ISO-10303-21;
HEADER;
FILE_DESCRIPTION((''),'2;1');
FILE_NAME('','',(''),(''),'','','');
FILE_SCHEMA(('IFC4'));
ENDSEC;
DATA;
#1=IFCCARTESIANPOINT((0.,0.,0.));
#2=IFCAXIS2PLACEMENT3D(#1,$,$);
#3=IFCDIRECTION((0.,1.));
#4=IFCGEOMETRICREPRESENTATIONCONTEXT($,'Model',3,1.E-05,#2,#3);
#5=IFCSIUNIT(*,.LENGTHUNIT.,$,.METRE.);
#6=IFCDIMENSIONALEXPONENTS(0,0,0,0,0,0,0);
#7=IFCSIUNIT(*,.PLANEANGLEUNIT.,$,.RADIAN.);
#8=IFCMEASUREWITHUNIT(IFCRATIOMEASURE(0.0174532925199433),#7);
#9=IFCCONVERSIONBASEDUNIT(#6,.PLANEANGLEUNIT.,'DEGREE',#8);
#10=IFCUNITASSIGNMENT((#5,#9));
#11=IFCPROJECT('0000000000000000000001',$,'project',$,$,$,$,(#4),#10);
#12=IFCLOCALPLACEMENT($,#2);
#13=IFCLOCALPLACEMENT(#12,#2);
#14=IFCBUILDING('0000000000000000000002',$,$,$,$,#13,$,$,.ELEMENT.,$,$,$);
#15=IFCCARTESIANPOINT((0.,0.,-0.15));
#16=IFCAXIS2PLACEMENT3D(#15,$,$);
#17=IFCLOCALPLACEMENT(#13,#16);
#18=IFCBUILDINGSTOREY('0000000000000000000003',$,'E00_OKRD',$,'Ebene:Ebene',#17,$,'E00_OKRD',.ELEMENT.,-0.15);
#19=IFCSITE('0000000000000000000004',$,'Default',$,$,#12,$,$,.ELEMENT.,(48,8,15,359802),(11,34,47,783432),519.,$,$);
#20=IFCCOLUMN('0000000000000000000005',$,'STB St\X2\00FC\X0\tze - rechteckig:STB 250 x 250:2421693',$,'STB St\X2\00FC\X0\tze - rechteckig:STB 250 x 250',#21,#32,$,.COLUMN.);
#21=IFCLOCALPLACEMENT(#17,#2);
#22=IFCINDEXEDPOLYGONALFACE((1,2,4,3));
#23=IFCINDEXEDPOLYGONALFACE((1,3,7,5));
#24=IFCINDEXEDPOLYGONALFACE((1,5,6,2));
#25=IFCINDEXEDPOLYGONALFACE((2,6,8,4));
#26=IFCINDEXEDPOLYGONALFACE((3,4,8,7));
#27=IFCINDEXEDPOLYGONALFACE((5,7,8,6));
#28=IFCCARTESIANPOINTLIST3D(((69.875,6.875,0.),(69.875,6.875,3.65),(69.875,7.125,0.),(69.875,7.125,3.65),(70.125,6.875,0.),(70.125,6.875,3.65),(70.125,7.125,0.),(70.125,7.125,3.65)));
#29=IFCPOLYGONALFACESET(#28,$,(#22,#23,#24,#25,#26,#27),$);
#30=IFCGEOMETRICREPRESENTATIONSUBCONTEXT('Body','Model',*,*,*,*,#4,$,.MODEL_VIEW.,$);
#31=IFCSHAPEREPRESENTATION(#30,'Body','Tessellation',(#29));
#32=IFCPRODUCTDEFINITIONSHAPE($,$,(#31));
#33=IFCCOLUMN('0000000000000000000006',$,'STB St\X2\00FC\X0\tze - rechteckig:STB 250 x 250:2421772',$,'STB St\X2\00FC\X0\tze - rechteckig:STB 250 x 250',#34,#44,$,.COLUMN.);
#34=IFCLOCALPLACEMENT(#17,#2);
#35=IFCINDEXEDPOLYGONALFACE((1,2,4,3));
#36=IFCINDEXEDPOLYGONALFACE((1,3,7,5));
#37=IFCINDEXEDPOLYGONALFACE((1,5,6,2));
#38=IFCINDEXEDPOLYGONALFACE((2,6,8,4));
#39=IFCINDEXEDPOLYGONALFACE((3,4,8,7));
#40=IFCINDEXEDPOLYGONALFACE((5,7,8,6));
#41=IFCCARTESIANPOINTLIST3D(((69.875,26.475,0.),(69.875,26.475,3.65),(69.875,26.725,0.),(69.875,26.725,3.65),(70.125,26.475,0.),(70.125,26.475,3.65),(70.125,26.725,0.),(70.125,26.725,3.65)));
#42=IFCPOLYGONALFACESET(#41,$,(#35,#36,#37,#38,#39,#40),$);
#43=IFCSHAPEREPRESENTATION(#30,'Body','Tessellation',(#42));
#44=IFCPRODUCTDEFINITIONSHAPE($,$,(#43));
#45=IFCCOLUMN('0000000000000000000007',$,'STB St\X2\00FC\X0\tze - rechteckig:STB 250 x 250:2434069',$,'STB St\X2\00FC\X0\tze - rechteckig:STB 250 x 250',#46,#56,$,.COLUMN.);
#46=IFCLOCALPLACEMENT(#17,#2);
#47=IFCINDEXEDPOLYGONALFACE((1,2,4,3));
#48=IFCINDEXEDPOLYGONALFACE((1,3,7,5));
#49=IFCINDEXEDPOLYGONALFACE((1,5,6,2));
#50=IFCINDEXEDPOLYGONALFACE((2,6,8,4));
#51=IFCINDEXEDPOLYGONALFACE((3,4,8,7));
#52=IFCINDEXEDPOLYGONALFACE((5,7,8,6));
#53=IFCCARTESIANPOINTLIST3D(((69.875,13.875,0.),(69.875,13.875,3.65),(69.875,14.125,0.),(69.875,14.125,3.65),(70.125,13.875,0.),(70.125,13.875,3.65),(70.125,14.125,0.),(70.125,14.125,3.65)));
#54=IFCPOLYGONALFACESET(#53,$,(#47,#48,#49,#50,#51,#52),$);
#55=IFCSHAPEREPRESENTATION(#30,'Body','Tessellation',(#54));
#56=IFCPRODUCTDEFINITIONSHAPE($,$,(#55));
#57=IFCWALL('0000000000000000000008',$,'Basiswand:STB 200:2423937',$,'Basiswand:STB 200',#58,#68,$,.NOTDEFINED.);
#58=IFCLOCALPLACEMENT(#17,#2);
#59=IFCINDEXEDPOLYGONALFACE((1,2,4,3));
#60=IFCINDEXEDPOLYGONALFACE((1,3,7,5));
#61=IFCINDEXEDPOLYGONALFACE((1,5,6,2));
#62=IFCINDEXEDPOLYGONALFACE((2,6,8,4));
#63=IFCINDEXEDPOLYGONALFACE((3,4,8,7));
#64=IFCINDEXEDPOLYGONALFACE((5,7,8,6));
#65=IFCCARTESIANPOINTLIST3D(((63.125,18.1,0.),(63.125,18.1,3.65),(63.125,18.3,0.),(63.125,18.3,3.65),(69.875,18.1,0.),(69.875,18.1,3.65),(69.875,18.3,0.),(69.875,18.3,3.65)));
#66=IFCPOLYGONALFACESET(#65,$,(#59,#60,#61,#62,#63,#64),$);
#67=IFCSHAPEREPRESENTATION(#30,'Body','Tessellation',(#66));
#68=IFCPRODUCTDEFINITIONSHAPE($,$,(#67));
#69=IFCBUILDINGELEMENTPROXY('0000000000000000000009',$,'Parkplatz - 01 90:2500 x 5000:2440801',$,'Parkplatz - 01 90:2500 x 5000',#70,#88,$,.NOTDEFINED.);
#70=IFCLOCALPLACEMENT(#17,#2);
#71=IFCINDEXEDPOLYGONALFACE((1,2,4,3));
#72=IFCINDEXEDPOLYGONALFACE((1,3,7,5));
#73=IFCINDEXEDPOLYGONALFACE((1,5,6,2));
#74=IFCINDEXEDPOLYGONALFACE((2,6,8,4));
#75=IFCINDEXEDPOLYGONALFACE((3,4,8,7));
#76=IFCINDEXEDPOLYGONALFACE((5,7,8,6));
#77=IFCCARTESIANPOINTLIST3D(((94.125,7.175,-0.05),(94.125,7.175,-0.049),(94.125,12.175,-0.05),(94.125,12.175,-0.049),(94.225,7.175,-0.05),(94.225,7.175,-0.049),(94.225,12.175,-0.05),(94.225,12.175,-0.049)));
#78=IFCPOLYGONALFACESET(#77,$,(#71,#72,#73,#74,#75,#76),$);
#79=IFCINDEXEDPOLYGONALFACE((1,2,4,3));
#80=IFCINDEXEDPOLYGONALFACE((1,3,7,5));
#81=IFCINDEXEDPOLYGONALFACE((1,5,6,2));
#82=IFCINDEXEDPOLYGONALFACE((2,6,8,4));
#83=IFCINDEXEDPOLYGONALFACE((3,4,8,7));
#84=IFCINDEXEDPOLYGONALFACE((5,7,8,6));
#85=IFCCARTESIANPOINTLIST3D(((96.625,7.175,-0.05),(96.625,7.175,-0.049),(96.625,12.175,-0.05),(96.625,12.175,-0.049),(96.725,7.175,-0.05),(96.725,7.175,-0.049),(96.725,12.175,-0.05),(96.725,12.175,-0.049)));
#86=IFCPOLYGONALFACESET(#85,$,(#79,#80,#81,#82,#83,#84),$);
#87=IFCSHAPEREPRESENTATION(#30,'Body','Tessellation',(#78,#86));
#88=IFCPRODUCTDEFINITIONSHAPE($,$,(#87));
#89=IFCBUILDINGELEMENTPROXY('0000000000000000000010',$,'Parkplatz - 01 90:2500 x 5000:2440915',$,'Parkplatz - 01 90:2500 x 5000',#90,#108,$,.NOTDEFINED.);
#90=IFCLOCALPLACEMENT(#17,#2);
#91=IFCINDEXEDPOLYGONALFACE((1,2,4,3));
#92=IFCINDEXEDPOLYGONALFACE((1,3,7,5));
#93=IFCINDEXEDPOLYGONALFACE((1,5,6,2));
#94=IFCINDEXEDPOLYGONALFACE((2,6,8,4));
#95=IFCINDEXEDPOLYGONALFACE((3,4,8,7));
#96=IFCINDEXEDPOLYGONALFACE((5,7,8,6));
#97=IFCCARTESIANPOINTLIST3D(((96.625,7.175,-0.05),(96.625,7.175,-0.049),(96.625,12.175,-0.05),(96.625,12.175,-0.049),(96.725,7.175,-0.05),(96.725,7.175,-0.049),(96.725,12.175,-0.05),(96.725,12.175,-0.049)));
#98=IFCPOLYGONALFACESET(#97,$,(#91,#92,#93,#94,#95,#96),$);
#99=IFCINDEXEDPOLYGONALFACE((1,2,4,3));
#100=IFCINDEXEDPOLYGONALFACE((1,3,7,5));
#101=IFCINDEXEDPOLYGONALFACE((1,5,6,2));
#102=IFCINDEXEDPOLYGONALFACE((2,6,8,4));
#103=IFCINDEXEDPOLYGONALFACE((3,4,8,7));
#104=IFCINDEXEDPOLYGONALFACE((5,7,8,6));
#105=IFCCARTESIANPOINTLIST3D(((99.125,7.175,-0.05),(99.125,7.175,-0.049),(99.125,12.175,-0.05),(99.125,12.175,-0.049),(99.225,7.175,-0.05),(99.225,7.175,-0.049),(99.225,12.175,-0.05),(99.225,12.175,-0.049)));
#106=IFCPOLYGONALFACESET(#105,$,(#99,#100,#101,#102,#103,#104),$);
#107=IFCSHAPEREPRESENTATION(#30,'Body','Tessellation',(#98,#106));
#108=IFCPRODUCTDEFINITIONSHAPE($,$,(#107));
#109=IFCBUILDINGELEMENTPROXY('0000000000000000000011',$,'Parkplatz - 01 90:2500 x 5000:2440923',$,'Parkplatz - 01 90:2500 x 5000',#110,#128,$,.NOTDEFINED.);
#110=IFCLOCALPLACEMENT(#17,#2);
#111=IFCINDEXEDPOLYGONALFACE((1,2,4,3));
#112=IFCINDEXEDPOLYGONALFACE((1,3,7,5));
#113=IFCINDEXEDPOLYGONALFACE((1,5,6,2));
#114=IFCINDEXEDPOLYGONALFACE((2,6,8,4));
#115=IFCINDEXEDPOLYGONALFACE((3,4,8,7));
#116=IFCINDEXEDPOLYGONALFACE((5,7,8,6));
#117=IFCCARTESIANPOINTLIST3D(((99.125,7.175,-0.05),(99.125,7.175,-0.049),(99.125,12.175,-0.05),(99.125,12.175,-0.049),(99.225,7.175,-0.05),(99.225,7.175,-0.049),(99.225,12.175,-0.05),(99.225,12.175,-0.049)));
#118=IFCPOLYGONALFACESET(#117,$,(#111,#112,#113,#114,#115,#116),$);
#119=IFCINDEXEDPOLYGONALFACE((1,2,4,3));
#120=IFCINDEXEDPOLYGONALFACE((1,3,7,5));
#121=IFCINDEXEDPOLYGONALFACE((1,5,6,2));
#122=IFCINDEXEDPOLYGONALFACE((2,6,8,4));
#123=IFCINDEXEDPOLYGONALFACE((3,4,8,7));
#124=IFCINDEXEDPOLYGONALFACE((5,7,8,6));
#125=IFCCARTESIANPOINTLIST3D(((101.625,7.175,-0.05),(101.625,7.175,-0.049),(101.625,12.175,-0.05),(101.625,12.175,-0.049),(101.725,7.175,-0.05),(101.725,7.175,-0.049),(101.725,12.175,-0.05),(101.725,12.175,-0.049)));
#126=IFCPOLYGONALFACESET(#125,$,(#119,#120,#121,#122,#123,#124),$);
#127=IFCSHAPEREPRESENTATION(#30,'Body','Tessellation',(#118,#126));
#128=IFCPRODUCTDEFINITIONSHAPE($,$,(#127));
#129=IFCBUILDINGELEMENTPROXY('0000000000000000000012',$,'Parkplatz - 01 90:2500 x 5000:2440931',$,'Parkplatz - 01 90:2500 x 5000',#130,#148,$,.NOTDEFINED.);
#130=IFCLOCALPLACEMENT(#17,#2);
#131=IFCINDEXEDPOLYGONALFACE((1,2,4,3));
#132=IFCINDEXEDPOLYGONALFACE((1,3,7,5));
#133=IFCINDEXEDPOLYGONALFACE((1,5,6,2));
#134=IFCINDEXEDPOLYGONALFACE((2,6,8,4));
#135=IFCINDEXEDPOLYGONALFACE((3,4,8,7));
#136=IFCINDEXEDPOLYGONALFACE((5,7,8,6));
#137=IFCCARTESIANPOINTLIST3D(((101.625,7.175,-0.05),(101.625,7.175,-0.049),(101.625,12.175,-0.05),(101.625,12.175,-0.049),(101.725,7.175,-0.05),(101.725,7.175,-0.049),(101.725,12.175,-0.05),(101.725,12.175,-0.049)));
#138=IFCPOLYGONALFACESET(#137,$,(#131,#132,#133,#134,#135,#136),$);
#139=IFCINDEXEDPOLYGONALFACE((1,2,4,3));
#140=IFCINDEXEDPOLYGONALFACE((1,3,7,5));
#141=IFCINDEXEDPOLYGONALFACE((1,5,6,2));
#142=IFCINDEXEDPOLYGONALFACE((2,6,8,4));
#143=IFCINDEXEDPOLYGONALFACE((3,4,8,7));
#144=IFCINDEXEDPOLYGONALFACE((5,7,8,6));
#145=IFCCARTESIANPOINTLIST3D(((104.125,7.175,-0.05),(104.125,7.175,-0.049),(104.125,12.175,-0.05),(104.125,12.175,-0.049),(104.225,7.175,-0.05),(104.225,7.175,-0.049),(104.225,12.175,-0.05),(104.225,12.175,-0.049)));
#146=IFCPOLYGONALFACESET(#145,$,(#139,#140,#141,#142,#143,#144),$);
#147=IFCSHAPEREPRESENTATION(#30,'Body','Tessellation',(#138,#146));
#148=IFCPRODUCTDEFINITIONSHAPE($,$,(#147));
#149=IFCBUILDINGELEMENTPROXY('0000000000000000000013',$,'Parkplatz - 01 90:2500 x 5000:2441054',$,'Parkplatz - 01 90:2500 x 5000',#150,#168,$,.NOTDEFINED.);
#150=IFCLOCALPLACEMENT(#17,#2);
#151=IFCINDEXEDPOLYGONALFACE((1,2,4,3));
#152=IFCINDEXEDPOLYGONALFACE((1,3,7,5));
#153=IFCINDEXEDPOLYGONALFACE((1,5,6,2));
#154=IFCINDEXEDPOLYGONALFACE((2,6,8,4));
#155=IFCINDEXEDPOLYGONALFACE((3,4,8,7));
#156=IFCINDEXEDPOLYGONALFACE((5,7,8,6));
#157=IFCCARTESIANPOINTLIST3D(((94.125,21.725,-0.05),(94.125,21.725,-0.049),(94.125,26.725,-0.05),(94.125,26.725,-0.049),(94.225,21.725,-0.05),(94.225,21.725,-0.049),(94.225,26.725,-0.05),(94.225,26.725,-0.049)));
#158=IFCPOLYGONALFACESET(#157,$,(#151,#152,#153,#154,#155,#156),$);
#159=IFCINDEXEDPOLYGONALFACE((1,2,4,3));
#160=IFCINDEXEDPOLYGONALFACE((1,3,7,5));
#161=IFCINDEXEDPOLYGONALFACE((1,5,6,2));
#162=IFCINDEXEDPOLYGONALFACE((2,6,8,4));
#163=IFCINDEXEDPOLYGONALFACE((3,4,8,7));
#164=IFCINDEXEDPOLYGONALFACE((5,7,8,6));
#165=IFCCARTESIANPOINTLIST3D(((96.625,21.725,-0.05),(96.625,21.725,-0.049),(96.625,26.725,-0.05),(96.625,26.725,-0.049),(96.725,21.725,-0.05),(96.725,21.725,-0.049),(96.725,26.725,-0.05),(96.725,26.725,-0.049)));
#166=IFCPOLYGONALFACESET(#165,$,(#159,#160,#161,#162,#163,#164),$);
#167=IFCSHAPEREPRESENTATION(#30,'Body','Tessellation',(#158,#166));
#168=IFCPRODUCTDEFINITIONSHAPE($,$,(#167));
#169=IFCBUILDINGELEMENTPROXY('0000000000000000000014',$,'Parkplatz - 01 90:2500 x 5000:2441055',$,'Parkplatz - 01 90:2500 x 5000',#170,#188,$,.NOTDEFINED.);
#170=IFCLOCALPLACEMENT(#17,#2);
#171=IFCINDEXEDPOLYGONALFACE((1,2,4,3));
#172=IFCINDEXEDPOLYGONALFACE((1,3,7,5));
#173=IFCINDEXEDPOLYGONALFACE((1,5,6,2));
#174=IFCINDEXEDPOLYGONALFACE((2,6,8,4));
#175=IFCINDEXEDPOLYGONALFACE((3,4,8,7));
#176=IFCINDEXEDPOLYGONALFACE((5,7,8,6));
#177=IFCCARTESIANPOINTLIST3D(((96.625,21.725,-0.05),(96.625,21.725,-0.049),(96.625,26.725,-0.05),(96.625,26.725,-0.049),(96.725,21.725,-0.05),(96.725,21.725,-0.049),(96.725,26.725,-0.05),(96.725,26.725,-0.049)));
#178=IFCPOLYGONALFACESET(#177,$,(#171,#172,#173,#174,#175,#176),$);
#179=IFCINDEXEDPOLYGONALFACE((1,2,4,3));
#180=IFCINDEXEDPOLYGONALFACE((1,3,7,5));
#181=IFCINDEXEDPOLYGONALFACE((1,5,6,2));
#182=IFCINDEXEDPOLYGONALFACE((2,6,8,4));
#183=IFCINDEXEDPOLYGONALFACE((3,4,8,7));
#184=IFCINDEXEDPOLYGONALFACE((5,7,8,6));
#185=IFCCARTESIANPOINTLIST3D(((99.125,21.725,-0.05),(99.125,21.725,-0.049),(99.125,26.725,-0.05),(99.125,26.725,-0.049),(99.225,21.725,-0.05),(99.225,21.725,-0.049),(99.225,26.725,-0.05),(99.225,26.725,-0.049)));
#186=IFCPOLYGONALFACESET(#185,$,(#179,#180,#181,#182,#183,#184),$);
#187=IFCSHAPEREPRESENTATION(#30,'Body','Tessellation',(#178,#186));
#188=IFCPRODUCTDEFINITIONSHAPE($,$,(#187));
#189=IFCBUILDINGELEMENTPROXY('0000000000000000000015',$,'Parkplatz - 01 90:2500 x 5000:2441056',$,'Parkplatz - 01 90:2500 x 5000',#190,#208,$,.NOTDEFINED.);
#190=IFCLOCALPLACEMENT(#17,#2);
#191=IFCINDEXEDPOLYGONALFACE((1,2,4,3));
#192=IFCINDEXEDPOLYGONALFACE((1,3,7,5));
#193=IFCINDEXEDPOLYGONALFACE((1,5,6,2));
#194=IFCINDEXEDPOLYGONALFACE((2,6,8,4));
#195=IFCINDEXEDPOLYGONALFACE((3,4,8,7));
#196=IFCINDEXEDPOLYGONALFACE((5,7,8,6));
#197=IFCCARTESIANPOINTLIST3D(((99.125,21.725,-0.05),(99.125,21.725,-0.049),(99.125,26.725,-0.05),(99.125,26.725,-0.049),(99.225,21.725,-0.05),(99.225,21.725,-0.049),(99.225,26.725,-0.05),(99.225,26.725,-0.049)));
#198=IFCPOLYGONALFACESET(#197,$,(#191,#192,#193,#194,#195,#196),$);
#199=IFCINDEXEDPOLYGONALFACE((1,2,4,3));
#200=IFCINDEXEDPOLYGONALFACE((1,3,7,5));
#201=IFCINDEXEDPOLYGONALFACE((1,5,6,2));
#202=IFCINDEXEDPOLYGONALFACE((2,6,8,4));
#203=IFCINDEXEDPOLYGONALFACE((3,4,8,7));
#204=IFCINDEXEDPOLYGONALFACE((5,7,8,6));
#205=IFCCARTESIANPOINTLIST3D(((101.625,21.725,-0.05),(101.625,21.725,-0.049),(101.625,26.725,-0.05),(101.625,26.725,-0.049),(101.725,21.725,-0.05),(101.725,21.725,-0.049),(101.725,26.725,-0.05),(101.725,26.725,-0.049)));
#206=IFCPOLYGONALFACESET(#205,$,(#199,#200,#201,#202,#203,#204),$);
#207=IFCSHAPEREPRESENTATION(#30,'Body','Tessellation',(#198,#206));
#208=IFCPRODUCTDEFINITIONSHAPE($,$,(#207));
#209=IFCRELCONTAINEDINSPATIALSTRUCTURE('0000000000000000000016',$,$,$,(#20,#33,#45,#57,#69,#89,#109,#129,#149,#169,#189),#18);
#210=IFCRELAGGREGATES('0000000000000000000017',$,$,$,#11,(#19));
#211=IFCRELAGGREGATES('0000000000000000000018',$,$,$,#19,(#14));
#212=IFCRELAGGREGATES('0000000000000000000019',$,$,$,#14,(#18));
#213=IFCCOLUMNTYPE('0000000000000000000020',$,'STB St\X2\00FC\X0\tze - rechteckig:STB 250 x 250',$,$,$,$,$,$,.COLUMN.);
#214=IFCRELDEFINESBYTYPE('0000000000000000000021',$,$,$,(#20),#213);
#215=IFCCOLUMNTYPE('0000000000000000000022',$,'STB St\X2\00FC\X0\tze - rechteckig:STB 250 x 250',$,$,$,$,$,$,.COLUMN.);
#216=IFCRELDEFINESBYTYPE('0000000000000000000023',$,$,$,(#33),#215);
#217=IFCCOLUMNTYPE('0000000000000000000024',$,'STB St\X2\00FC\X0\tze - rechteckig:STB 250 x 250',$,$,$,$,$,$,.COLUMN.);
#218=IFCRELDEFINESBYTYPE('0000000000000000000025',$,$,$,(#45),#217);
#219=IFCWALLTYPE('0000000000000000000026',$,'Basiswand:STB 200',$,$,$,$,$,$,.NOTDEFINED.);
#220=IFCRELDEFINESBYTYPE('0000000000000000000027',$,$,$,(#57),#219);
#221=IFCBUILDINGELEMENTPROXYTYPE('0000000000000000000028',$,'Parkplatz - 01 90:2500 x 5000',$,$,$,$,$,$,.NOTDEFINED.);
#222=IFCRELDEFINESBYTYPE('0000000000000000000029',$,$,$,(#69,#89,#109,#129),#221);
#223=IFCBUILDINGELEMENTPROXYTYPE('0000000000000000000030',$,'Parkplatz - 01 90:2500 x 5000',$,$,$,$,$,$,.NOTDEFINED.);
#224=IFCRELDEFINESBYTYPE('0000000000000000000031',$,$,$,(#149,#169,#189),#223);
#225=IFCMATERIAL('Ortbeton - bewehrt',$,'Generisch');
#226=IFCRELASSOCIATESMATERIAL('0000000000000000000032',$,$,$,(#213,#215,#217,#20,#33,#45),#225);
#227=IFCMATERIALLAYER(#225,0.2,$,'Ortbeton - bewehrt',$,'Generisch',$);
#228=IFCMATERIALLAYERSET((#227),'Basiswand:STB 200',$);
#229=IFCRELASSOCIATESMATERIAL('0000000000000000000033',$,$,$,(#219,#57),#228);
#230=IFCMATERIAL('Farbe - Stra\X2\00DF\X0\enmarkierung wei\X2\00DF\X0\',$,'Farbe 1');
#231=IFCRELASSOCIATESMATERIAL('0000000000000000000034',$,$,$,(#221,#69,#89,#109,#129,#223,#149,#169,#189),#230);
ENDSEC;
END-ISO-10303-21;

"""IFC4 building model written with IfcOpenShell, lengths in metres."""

from ifc_helpers import new_model, entity, si_unit, converted_unit, direction, frame, frame_2d, origin, origin_2d_with_axis, place, context, subcontext, project, spatial, rectangle, extrude, source, transform, mapped, material, layer, layer_set, layer_usage, material_profile, profile_set, profile_usage, type_object, type_shapes, element, save


model = new_model("IFC4")

# Units and contexts
model_context = context("Model", 3, precision=1e-05, world=origin(), true_north=direction((0.0, 1.0)))
body_context = subcontext(model_context, "Body", "Model", "MODEL_VIEW")
ifc_project = project(units=[si_unit("LENGTHUNIT", "METRE"), converted_unit("PLANEANGLEUNIT", "DEGREE", entity("IfcRatioMeasure", 0.0174532925199433), si_unit("PLANEANGLEUNIT", "RADIAN"), dimensions=[0, 0, 0, 0, 0, 0, 0])], contexts=[model_context])

# Site, building, storey
site_placement = place(None, frame((0.0, 0.0, 0.0)))
site = spatial("IfcSite", under=ifc_project, at=site_placement, Name="Default", CompositionType="ELEMENT", RefLatitude=(48, 8, 15, 359802), RefLongitude=(11, 34, 47, 783432), RefElevation=519.0)
building_placement = place(site_placement, origin())
building = spatial("IfcBuilding", under=site, at=building_placement, CompositionType="ELEMENT")
storey_placement = place(building_placement, frame((0.0, 0.0, -0.15)))
storey = spatial("IfcBuildingStorey", under=building, at=storey_placement, Name="E00_OKRD", ObjectType="Ebene:Ebene", LongName="E00_OKRD", CompositionType="ELEMENT", Elevation=-0.15)

# Columns
ifc_material_1 = material(Name="Ortbeton - bewehrt", Category="Generisch")
ifc_material_profile = material_profile(ifc_material_1, rectangle(XDim=0.25, YDim=0.25, at=origin_2d_with_axis()), Name="STB 250 x 250")
ifc_profile_set = profile_set([ifc_material_profile], Name="STB 250 x 250")
ifc_profile_usage_1 = profile_usage(ifc_profile_set)
column_type_1 = type_object("IfcColumnType", Name="STB Stütze - rechteckig:STB 250 x 250", PredefinedType="COLUMN", material=ifc_profile_set)
shared_shape_1 = source(origin(), body_context, "Body", "SweptSolid", [
    extrude(rectangle(XDim=0.25, YDim=0.25, at=frame_2d((0.0, 0.0), x_axis=(1.0, 0.0))), frame((0.125, 0.125, 0.0), z_axis=(0.0, 0.0, 1.0), x_axis=(-1.0, 0.0, 0.0)), (0.0, 0.0, 1.0), 3.65),
])
type_shapes(column_type_1, [shared_shape_1])
column_1_placement = place(storey_placement, frame((69.875, 6.875, 0.0)))
element("IfcColumn", 1, at=column_1_placement, inside=storey, type_object=column_type_1, material=ifc_profile_usage_1, Name="STB Stütze - rechteckig:STB 250 x 250:2421693", ObjectType="STB Stütze - rechteckig:STB 250 x 250", PredefinedType="COLUMN", context=body_context, shape_type="MappedRepresentation", body=[
    mapped(shared_shape_1, transform((0.0, 0.0, 0.0), scale=1.0)),
])
ifc_profile_usage_2 = profile_usage(ifc_profile_set)
column_type_2 = type_object("IfcColumnType", Name="STB Stütze - rechteckig:STB 250 x 250", PredefinedType="COLUMN", material=ifc_profile_set)
shared_shape_2 = source(origin(), body_context, "Body", "SweptSolid", [
    extrude(rectangle(XDim=0.25, YDim=0.25, at=frame_2d((0.0, 0.0), x_axis=(1.0, 0.0))), frame((0.125, 0.125, 0.0), z_axis=(0.0, 0.0, 1.0), x_axis=(-1.0, 0.0, 0.0)), (0.0, 0.0, 1.0), 3.65),
])
type_shapes(column_type_2, [shared_shape_2])
column_2_placement = place(storey_placement, frame((69.875, 26.475, 0.0)))
element("IfcColumn", 2, at=column_2_placement, inside=storey, type_object=column_type_2, material=ifc_profile_usage_2, Name="STB Stütze - rechteckig:STB 250 x 250:2421772", ObjectType="STB Stütze - rechteckig:STB 250 x 250", PredefinedType="COLUMN", context=body_context, shape_type="MappedRepresentation", body=[
    mapped(shared_shape_2, transform((0.0, 0.0, 0.0), scale=1.0)),
])
ifc_profile_usage_3 = profile_usage(ifc_profile_set)
column_type_3 = type_object("IfcColumnType", Name="STB Stütze - rechteckig:STB 250 x 250", PredefinedType="COLUMN", material=ifc_profile_set)
shared_shape_3 = source(origin(), body_context, "Body", "SweptSolid", [
    extrude(rectangle(XDim=0.25, YDim=0.25, at=frame_2d((0.0, 0.0), x_axis=(1.0, 0.0))), frame((0.125, 0.125, 0.0), z_axis=(0.0, 0.0, 1.0), x_axis=(-1.0, 0.0, 0.0)), (0.0, 0.0, 1.0), 3.65),
])
type_shapes(column_type_3, [shared_shape_3])
column_3_placement = place(storey_placement, frame((69.875, 13.875, 0.0)))
element("IfcColumn", 3, at=column_3_placement, inside=storey, type_object=column_type_3, material=ifc_profile_usage_3, Name="STB Stütze - rechteckig:STB 250 x 250:2434069", ObjectType="STB Stütze - rechteckig:STB 250 x 250", PredefinedType="COLUMN", context=body_context, shape_type="MappedRepresentation", body=[
    mapped(shared_shape_3, transform((0.0, 0.0, 0.0), scale=1.0)),
])

# Wall
ifc_layer = layer(ifc_material_1, 0.2, Name="Ortbeton - bewehrt", Category="Generisch")
ifc_layer_set = layer_set([ifc_layer], Name="Basiswand:STB 200")
ifc_layer_usage = layer_usage(ifc_layer_set, "AXIS2", "NEGATIVE", 0.1)
wall_type = type_object("IfcWallType", Name="Basiswand:STB 200", PredefinedType="NOTDEFINED", material=ifc_layer_set)
wall_placement = place(storey_placement, frame((69.875, 18.2, 0.0), z_axis=(0.0, 0.0, 1.0), x_axis=(-1.0, 0.0, 0.0)))
element("IfcWall", 4, at=wall_placement, inside=storey, type_object=wall_type, material=ifc_layer_usage, Name="Basiswand:STB 200:2423937", ObjectType="Basiswand:STB 200", PredefinedType="NOTDEFINED", context=body_context, shape_type="SweptSolid", body=[
    extrude(rectangle(XDim=6.75, YDim=0.2, at=frame_2d((3.375, 0.0), x_axis=(-1.0, 0.0))), origin(), (0.0, 0.0, 1.0), 3.65),
])

# Building element proxies
ifc_material_2 = material(Name="Farbe - Straßenmarkierung weiß", Category="Farbe 1")
building_element_proxy_type_1 = type_object("IfcBuildingElementProxyType", Name="Parkplatz - 01 90:2500 x 5000", PredefinedType="NOTDEFINED", material=ifc_material_2)
shared_shape_4 = source(origin(), body_context, "Body", "SweptSolid", [
    extrude(rectangle(XDim=5.0, YDim=0.1, at=origin_2d_with_axis()), frame((2.5456, -2.5, 0.0), z_axis=(0.0, 0.0, 1.0), x_axis=(0.0, -1.0, 0.0)), (0.0, 0.0, 1.0), 0.001),
    extrude(rectangle(XDim=0.1, YDim=5.0, at=origin_2d_with_axis()), frame((0.0456, -2.5, 0.0), z_axis=(0.0, 0.0, 1.0), x_axis=(-1.0, 0.0, 0.0)), (0.0, 0.0, 1.0), 0.001),
])
type_shapes(building_element_proxy_type_1, [shared_shape_4])
for number, where, z_axis, x_axis, name in (
    (5, (96.7206, 7.175, -0.05), (0.0, 0.0, 1.0), (-1.0, 0.0, 0.0), "Parkplatz - 01 90:2500 x 5000:2440801"),
    (6, (99.2206, 7.175, -0.05), (0.0, 0.0, 1.0), (-1.0, 0.0, 0.0), "Parkplatz - 01 90:2500 x 5000:2440915"),
    (7, (101.7206, 7.175, -0.05), (0.0, 0.0, 1.0), (-1.0, 0.0, 0.0), "Parkplatz - 01 90:2500 x 5000:2440923"),
    (8, (104.2206, 7.175, -0.05), (0.0, 0.0, 1.0), (-1.0, 0.0, 0.0), "Parkplatz - 01 90:2500 x 5000:2440931"),
):
    element("IfcBuildingElementProxy", number, at=place(storey_placement, frame(where, z_axis=z_axis, x_axis=x_axis)), inside=storey, type_object=building_element_proxy_type_1, material=ifc_material_2, Name=name, ObjectType="Parkplatz - 01 90:2500 x 5000", PredefinedType="NOTDEFINED", context=body_context, shape_type="MappedRepresentation", body=[
        mapped(shared_shape_4, transform((0.0, 0.0, 0.0), scale=1.0)),
    ])
building_element_proxy_type_2 = type_object("IfcBuildingElementProxyType", Name="Parkplatz - 01 90:2500 x 5000", PredefinedType="NOTDEFINED", material=ifc_material_2)
shared_shape_5 = source(origin(), body_context, "Body", "SweptSolid", [
    extrude(rectangle(XDim=0.1, YDim=5.0, at=origin_2d_with_axis()), frame((2.5456, 2.5, 0.0)), (0.0, 0.0, 1.0), 0.001),
    extrude(rectangle(XDim=5.0, YDim=0.1, at=origin_2d_with_axis()), frame((0.0456, 2.5, 0.0), z_axis=(0.0, 0.0, 1.0), x_axis=(0.0, 1.0, 0.0)), (0.0, 0.0, 1.0), 0.001),
])
type_shapes(building_element_proxy_type_2, [shared_shape_5])
for number, where, z_axis, x_axis, name in (
    (9, (96.7206, 26.725, -0.05), (0.0, 0.0, 1.0), (-1.0, 0.0, 0.0), "Parkplatz - 01 90:2500 x 5000:2441054"),
    (10, (99.2206, 26.725, -0.05), (0.0, 0.0, 1.0), (-1.0, 0.0, 0.0), "Parkplatz - 01 90:2500 x 5000:2441055"),
    (11, (101.7206, 26.725, -0.05), (0.0, 0.0, 1.0), (-1.0, 0.0, 0.0), "Parkplatz - 01 90:2500 x 5000:2441056"),
):
    element("IfcBuildingElementProxy", number, at=place(storey_placement, frame(where, z_axis=z_axis, x_axis=x_axis)), inside=storey, type_object=building_element_proxy_type_2, material=ifc_material_2, Name=name, ObjectType="Parkplatz - 01 90:2500 x 5000", PredefinedType="NOTDEFINED", context=body_context, shape_type="MappedRepresentation", body=[
        mapped(shared_shape_5, transform((0.0, 0.0, 0.0), scale=1.0)),
    ])

save(model, "model.ifc")
